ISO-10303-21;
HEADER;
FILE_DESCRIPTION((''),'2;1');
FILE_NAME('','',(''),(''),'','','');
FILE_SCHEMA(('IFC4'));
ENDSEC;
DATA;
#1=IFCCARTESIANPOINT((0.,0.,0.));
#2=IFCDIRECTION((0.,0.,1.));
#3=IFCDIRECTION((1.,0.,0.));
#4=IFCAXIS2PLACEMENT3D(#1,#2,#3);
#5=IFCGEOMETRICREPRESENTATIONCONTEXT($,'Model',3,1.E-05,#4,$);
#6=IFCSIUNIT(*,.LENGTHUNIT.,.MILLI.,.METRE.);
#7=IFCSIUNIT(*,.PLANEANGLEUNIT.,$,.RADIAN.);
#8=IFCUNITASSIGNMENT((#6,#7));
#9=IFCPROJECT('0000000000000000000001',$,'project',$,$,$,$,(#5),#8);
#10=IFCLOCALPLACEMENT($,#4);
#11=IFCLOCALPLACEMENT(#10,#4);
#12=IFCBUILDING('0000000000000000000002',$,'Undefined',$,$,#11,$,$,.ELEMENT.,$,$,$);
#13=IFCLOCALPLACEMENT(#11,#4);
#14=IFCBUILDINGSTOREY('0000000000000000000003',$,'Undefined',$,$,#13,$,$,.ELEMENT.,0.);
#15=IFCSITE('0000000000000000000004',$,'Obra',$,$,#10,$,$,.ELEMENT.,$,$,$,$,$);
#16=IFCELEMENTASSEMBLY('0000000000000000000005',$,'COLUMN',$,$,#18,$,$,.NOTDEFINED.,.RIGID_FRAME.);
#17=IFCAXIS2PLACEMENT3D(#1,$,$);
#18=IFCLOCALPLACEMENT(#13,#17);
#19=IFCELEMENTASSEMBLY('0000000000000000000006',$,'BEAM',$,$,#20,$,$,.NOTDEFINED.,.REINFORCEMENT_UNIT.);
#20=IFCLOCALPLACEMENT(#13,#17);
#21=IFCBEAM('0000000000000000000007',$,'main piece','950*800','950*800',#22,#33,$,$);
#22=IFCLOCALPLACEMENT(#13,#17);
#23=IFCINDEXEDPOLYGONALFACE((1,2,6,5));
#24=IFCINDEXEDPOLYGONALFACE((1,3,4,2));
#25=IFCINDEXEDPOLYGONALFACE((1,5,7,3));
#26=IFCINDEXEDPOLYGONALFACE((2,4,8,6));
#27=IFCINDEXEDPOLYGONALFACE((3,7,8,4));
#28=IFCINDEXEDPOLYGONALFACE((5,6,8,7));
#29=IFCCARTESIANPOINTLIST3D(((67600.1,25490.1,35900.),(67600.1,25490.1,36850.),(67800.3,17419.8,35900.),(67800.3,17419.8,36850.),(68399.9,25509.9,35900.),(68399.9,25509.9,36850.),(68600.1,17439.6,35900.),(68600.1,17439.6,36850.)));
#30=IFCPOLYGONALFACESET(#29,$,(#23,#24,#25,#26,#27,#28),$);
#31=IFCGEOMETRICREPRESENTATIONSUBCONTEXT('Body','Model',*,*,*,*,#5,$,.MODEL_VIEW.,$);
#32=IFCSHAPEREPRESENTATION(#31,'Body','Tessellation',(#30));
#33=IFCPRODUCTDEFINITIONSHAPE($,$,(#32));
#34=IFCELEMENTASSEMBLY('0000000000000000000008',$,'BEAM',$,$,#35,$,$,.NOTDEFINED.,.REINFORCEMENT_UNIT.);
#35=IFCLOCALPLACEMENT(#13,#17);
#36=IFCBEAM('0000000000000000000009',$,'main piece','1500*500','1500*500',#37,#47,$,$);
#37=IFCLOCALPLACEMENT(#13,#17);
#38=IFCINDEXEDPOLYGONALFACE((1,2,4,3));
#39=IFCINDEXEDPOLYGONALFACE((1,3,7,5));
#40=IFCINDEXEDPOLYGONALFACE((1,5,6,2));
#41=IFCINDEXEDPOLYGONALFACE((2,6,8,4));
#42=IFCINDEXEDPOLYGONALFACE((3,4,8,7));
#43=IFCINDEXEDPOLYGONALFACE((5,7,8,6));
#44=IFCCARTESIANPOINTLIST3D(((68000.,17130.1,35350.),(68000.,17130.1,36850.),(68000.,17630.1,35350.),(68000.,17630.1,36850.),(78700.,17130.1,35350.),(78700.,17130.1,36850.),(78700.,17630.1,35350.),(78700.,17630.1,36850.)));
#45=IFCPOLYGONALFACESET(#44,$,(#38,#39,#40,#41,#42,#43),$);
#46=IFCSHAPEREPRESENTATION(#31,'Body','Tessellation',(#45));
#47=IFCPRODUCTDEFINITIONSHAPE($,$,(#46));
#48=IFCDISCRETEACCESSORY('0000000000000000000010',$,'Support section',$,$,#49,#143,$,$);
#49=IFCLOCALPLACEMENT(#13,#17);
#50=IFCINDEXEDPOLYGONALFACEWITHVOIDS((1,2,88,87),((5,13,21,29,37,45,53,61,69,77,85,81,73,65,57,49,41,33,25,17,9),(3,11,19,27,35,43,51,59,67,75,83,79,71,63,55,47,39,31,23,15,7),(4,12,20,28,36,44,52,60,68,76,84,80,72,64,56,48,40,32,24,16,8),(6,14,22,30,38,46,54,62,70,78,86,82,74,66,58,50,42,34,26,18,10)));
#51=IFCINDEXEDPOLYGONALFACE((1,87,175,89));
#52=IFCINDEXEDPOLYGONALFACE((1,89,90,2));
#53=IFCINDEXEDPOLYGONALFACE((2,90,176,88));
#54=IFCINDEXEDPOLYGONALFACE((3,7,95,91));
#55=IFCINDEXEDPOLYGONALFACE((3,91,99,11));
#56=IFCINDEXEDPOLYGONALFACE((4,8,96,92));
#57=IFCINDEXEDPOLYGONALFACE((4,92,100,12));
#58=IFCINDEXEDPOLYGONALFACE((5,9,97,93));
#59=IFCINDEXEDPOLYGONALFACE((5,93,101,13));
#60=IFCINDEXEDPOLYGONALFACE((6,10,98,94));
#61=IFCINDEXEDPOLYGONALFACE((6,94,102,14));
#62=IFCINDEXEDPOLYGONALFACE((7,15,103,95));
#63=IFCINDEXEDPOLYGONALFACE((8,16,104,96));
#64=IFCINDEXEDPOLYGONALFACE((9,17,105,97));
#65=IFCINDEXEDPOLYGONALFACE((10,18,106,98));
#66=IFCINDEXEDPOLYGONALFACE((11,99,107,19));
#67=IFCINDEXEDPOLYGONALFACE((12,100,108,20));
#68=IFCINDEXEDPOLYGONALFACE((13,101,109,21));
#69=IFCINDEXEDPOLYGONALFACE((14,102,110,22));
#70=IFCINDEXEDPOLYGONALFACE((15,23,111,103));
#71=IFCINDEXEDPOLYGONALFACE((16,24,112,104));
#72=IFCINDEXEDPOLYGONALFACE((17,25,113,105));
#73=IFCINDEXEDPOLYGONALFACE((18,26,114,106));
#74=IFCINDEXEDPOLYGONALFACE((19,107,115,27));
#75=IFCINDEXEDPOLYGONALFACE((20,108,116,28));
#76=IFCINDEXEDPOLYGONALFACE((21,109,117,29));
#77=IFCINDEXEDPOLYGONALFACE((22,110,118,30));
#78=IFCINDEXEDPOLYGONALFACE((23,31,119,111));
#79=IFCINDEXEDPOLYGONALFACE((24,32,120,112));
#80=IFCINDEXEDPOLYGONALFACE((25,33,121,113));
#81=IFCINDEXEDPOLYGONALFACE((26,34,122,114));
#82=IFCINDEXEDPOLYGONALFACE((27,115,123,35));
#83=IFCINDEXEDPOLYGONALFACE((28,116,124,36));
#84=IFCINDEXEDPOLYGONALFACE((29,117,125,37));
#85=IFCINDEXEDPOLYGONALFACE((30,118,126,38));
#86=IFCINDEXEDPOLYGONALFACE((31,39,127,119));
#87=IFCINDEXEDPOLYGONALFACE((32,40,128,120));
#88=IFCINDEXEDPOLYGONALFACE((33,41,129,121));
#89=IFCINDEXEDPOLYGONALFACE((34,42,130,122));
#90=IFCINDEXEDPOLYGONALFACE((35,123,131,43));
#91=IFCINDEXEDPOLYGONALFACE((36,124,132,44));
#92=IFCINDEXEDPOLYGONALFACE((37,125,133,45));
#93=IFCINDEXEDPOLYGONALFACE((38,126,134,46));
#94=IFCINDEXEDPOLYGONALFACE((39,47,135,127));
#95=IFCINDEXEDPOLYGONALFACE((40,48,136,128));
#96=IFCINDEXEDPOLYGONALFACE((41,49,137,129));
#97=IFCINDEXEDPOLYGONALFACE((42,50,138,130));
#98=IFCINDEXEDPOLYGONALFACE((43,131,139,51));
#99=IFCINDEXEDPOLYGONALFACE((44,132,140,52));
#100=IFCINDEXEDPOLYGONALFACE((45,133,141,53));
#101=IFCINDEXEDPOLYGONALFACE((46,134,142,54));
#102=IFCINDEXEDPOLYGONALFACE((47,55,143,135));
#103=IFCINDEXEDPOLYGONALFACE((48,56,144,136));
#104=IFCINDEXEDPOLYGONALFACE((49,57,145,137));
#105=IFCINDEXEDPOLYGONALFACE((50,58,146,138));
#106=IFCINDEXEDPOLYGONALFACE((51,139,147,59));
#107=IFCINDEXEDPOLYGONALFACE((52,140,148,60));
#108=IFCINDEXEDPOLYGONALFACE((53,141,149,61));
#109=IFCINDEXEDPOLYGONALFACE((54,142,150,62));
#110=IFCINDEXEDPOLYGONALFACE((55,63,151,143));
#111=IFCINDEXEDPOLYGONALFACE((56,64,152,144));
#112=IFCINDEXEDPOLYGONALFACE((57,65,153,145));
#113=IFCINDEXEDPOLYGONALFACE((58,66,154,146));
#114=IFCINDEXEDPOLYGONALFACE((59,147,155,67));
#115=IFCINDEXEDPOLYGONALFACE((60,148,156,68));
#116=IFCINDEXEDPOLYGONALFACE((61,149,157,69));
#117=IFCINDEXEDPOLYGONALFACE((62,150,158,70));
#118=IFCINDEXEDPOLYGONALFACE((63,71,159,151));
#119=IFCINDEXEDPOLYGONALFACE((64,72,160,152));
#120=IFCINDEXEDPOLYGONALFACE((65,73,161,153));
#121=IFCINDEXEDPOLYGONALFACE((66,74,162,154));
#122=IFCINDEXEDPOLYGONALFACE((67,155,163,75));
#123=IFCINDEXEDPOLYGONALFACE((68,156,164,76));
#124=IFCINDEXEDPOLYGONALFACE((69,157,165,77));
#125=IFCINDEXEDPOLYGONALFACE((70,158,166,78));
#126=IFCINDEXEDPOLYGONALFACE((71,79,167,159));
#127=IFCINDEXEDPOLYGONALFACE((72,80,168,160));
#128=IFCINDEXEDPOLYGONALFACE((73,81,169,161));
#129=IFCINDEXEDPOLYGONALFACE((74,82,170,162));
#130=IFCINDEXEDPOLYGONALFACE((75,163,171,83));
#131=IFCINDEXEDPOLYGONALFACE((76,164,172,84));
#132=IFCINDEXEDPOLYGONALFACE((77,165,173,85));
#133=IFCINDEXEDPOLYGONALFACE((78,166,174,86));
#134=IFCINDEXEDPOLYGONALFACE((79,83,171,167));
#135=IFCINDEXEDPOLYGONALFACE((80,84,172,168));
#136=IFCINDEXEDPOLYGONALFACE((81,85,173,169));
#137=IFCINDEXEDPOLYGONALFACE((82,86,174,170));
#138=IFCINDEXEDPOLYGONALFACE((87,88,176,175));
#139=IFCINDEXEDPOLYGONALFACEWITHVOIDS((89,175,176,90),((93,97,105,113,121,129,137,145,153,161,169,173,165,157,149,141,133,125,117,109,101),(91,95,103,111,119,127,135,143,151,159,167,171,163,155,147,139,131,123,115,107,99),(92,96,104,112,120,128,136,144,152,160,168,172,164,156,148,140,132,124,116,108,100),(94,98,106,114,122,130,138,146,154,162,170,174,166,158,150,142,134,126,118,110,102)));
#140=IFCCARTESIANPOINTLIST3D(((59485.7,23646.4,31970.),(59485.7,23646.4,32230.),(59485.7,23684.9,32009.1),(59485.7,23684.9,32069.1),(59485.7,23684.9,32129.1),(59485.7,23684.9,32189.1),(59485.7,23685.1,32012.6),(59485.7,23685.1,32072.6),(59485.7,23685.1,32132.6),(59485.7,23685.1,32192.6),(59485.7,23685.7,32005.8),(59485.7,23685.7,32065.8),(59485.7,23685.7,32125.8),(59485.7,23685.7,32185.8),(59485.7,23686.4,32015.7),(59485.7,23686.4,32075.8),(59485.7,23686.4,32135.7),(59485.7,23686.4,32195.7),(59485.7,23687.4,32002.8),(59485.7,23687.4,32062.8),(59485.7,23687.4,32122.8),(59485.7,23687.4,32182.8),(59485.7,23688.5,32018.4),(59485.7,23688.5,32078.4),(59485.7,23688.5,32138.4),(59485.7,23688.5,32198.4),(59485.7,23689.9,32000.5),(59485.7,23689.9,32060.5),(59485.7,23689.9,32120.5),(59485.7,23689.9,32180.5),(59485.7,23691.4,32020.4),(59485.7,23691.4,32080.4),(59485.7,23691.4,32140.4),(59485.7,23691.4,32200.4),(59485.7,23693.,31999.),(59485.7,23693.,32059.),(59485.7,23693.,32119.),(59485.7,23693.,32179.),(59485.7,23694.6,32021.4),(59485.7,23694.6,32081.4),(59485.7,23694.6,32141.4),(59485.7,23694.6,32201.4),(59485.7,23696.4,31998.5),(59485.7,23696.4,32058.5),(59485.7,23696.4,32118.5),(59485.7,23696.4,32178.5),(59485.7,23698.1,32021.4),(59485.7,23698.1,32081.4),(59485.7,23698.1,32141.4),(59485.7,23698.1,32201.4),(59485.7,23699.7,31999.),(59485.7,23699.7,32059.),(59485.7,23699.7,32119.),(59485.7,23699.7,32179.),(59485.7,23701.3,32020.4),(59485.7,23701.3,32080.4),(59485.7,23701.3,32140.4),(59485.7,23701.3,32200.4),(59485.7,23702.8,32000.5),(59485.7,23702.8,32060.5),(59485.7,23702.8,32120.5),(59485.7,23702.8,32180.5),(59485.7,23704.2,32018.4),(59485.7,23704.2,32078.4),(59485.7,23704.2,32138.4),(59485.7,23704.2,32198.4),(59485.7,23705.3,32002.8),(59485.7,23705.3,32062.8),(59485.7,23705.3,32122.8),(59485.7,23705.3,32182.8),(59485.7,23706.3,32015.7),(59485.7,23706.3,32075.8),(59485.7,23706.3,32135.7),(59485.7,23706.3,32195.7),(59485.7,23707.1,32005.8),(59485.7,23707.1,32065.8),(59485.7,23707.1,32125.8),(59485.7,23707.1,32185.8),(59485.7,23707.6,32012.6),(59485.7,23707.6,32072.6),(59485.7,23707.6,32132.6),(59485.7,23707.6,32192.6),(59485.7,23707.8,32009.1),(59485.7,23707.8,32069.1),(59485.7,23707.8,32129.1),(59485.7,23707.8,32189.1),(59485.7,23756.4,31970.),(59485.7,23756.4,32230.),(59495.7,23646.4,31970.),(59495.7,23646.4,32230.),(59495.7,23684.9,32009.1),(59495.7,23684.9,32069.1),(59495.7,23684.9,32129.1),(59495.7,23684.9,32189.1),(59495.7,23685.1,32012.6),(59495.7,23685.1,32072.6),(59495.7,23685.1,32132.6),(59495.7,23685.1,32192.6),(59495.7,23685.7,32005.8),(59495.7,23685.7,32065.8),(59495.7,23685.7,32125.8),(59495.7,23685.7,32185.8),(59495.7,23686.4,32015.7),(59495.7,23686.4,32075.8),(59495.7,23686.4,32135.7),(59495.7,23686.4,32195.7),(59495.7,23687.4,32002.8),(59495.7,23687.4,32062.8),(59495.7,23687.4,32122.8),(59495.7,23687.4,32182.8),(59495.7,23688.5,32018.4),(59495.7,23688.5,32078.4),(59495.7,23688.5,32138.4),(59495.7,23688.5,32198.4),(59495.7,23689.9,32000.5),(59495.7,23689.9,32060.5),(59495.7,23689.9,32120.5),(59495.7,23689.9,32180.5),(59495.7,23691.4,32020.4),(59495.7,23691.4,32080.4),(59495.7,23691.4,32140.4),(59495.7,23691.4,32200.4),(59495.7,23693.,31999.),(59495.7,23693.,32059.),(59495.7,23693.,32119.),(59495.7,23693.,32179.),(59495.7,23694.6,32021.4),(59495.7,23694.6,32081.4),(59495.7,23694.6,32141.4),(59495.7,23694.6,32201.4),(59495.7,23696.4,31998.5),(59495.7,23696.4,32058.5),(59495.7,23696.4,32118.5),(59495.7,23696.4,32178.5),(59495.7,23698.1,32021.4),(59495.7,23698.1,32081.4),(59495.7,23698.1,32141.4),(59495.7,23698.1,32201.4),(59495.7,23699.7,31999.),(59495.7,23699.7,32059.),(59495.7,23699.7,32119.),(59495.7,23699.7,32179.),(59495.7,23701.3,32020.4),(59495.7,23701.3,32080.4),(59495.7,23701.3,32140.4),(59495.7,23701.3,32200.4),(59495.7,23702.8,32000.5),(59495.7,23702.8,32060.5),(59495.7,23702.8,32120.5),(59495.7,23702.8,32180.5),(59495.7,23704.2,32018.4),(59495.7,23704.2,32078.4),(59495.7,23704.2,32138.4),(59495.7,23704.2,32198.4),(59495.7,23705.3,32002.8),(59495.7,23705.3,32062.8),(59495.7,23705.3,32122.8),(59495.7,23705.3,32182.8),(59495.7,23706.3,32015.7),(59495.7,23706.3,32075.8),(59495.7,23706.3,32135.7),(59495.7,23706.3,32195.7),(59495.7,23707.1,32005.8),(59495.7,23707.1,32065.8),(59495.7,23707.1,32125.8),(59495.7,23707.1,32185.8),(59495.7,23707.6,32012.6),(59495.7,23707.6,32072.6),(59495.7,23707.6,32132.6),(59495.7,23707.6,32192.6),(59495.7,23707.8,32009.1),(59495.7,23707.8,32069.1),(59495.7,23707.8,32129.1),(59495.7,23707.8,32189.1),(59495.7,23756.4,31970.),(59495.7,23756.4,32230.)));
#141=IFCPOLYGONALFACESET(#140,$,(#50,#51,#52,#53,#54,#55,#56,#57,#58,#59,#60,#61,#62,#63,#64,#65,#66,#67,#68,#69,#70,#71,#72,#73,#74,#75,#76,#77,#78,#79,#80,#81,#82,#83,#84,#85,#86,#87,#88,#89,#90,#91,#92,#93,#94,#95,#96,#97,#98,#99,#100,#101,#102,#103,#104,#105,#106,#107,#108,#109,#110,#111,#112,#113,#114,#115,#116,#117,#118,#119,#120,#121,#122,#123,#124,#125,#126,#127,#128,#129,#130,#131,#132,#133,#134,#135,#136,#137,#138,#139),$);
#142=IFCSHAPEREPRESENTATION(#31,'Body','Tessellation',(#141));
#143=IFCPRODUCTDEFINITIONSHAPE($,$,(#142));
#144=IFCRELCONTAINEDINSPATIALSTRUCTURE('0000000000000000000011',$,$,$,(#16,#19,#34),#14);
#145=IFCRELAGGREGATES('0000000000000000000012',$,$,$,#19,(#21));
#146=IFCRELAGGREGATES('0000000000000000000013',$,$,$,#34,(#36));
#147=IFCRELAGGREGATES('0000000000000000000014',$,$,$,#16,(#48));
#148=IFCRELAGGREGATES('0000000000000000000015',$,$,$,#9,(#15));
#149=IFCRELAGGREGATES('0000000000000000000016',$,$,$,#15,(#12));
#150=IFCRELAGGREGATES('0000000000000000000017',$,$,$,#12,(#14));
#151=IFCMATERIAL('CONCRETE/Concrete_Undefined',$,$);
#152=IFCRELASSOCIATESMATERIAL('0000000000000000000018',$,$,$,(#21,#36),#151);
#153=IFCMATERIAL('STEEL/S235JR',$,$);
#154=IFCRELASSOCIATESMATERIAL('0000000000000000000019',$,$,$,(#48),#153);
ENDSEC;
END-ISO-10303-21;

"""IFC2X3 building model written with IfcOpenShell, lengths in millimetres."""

from ifc_helpers import new_model, si_unit, frame, origin_with_axes, origin_2d_with_axis, place, context, subcontext, project, spatial, rectangle, circle, extrude, source, transform, mapped, material, element, aggregate, save


model = new_model("IFC2X3")

# Units and contexts
model_context = context("Model", 3, precision=1e-05, world=origin_with_axes())
body_context = subcontext(model_context, "Body", "Model", "MODEL_VIEW")
ifc_project = project(units=[si_unit("LENGTHUNIT", "METRE", prefix="MILLI"), si_unit("PLANEANGLEUNIT", "RADIAN")], contexts=[model_context])

# Site, building, storey
site_placement = place(None, origin_with_axes())
site = spatial("IfcSite", under=ifc_project, at=site_placement, Name="Obra", CompositionType="ELEMENT")
building_placement = place(site_placement, origin_with_axes())
building = spatial("IfcBuilding", under=site, at=building_placement, Name="Undefined", CompositionType="ELEMENT")
storey_placement = place(building_placement, origin_with_axes())
storey = spatial("IfcBuildingStorey", under=building, at=storey_placement, Name="Undefined", CompositionType="ELEMENT", Elevation=0.0)

# Element assembly
ifc_material_1 = material(Name="STEEL/S235JR")
assembly_1_placement = place(storey_placement, origin_with_axes())
assembly_1 = element("IfcElementAssembly", 1, at=assembly_1_placement, inside=storey, Name="COLUMN", AssemblyPlace="NOTDEFINED", PredefinedType="RIGID_FRAME")

# Element assemblies, beams
ifc_material_2 = material(Name="CONCRETE/Concrete_Undefined")
assembly_2_placement = place(storey_placement, origin_with_axes())
assembly_2 = element("IfcElementAssembly", 2, at=assembly_2_placement, inside=storey, Name="BEAM", AssemblyPlace="NOTDEFINED", PredefinedType="REINFORCEMENT_UNIT")
beam_1_placement = place(assembly_2_placement, frame((68000.0, 25500.0, 36375.0), z_axis=(0.0, 0.0, 1.0), x_axis=(0.024801, -0.999692, 0.0)))
beam_1 = element("IfcBeam", 3, at=beam_1_placement, material=ifc_material_2, Name="main piece", Description="950*800", ObjectType="950*800", context=body_context, shape_type="SweptSolid", body=[
    extrude(rectangle(XDim=800.0, YDim=950.0, at=origin_2d_with_axis()), frame((8072.8, 0.0, 0.0), z_axis=(-1.0, 0.0, 0.0), x_axis=(0.0, -1.0, 0.0)), (0.0, 0.0, 1.0), 8072.8),
])
aggregate(assembly_2, [beam_1])
assembly_3_placement = place(storey_placement, origin_with_axes())
assembly_3 = element("IfcElementAssembly", 4, at=assembly_3_placement, inside=storey, Name="BEAM", AssemblyPlace="NOTDEFINED", PredefinedType="REINFORCEMENT_UNIT")
beam_2_placement = place(assembly_3_placement, frame((68000.0, 17380.1, 36100.0), z_axis=(0.0, 0.0, 1.0), x_axis=(1.0, 0.0, 0.0)))
beam_2 = element("IfcBeam", 5, at=beam_2_placement, material=ifc_material_2, Name="main piece", Description="1500*500", ObjectType="1500*500", context=body_context, shape_type="SweptSolid", body=[
    extrude(rectangle(XDim=500.0, YDim=1500.0, at=origin_2d_with_axis()), frame((10700.0, 0.0, 0.0), z_axis=(-1.0, 0.0, 0.0), x_axis=(0.0, -1.0, 0.0)), (0.0, 0.0, 1.0), 10700.0),
])
aggregate(assembly_3, [beam_2])

# Discrete accessory, opening
discrete_accessory_1_placement = place(assembly_1_placement, frame((59490.7, 23701.4, 31970.0), z_axis=(0.0, 0.0, 1.0), x_axis=(0.0, 1.0, 0.0)))
discrete_accessory_1 = element("IfcDiscreteAccessory", 6, at=discrete_accessory_1_placement, material=ifc_material_1, Name="Support section", context=body_context, shape_type="SweptSolid", body=[
    extrude(rectangle(XDim=10.0, YDim=110.0, at=origin_2d_with_axis()), frame((0.0, 0.0, 260.0), z_axis=(0.0, 0.0, -1.0), x_axis=(0.0, 1.0, 0.0)), (0.0, 0.0, 1.0), 260.0),
])
shared_shape_1 = source(origin_with_axes(), body_context, "Body", "SweptSolid", [
    extrude(circle(Radius=11.5, at=origin_2d_with_axis()), frame((0.0, -14.4, 0.0), z_axis=(0.0, 1.0, 0.0), x_axis=(1.0, 0.0, 0.0)), (0.0, 0.0, 1.0), 10.2),
])
opening_1_placement = place(assembly_1_placement, frame((59500.0, 23746.4, 32300.0), z_axis=(0.0, -1.0, 0.0), x_axis=(0.0, 0.0, -1.0)))
element("IfcOpeningElement", 7, at=opening_1_placement, cuts=discrete_accessory_1, ObjectType="Opening", context=body_context, shape_type="MappedRepresentation", body=[
    mapped(shared_shape_1, transform((110.0, 0.0, 50.0))),
    mapped(shared_shape_1, transform((170.0, 0.0, 50.0))),
    mapped(shared_shape_1, transform((230.0, 0.0, 50.0))),
    mapped(shared_shape_1, transform((290.0, 0.0, 50.0))),
])
aggregate(assembly_1, [discrete_accessory_1])

save(model, "model.ifc")
